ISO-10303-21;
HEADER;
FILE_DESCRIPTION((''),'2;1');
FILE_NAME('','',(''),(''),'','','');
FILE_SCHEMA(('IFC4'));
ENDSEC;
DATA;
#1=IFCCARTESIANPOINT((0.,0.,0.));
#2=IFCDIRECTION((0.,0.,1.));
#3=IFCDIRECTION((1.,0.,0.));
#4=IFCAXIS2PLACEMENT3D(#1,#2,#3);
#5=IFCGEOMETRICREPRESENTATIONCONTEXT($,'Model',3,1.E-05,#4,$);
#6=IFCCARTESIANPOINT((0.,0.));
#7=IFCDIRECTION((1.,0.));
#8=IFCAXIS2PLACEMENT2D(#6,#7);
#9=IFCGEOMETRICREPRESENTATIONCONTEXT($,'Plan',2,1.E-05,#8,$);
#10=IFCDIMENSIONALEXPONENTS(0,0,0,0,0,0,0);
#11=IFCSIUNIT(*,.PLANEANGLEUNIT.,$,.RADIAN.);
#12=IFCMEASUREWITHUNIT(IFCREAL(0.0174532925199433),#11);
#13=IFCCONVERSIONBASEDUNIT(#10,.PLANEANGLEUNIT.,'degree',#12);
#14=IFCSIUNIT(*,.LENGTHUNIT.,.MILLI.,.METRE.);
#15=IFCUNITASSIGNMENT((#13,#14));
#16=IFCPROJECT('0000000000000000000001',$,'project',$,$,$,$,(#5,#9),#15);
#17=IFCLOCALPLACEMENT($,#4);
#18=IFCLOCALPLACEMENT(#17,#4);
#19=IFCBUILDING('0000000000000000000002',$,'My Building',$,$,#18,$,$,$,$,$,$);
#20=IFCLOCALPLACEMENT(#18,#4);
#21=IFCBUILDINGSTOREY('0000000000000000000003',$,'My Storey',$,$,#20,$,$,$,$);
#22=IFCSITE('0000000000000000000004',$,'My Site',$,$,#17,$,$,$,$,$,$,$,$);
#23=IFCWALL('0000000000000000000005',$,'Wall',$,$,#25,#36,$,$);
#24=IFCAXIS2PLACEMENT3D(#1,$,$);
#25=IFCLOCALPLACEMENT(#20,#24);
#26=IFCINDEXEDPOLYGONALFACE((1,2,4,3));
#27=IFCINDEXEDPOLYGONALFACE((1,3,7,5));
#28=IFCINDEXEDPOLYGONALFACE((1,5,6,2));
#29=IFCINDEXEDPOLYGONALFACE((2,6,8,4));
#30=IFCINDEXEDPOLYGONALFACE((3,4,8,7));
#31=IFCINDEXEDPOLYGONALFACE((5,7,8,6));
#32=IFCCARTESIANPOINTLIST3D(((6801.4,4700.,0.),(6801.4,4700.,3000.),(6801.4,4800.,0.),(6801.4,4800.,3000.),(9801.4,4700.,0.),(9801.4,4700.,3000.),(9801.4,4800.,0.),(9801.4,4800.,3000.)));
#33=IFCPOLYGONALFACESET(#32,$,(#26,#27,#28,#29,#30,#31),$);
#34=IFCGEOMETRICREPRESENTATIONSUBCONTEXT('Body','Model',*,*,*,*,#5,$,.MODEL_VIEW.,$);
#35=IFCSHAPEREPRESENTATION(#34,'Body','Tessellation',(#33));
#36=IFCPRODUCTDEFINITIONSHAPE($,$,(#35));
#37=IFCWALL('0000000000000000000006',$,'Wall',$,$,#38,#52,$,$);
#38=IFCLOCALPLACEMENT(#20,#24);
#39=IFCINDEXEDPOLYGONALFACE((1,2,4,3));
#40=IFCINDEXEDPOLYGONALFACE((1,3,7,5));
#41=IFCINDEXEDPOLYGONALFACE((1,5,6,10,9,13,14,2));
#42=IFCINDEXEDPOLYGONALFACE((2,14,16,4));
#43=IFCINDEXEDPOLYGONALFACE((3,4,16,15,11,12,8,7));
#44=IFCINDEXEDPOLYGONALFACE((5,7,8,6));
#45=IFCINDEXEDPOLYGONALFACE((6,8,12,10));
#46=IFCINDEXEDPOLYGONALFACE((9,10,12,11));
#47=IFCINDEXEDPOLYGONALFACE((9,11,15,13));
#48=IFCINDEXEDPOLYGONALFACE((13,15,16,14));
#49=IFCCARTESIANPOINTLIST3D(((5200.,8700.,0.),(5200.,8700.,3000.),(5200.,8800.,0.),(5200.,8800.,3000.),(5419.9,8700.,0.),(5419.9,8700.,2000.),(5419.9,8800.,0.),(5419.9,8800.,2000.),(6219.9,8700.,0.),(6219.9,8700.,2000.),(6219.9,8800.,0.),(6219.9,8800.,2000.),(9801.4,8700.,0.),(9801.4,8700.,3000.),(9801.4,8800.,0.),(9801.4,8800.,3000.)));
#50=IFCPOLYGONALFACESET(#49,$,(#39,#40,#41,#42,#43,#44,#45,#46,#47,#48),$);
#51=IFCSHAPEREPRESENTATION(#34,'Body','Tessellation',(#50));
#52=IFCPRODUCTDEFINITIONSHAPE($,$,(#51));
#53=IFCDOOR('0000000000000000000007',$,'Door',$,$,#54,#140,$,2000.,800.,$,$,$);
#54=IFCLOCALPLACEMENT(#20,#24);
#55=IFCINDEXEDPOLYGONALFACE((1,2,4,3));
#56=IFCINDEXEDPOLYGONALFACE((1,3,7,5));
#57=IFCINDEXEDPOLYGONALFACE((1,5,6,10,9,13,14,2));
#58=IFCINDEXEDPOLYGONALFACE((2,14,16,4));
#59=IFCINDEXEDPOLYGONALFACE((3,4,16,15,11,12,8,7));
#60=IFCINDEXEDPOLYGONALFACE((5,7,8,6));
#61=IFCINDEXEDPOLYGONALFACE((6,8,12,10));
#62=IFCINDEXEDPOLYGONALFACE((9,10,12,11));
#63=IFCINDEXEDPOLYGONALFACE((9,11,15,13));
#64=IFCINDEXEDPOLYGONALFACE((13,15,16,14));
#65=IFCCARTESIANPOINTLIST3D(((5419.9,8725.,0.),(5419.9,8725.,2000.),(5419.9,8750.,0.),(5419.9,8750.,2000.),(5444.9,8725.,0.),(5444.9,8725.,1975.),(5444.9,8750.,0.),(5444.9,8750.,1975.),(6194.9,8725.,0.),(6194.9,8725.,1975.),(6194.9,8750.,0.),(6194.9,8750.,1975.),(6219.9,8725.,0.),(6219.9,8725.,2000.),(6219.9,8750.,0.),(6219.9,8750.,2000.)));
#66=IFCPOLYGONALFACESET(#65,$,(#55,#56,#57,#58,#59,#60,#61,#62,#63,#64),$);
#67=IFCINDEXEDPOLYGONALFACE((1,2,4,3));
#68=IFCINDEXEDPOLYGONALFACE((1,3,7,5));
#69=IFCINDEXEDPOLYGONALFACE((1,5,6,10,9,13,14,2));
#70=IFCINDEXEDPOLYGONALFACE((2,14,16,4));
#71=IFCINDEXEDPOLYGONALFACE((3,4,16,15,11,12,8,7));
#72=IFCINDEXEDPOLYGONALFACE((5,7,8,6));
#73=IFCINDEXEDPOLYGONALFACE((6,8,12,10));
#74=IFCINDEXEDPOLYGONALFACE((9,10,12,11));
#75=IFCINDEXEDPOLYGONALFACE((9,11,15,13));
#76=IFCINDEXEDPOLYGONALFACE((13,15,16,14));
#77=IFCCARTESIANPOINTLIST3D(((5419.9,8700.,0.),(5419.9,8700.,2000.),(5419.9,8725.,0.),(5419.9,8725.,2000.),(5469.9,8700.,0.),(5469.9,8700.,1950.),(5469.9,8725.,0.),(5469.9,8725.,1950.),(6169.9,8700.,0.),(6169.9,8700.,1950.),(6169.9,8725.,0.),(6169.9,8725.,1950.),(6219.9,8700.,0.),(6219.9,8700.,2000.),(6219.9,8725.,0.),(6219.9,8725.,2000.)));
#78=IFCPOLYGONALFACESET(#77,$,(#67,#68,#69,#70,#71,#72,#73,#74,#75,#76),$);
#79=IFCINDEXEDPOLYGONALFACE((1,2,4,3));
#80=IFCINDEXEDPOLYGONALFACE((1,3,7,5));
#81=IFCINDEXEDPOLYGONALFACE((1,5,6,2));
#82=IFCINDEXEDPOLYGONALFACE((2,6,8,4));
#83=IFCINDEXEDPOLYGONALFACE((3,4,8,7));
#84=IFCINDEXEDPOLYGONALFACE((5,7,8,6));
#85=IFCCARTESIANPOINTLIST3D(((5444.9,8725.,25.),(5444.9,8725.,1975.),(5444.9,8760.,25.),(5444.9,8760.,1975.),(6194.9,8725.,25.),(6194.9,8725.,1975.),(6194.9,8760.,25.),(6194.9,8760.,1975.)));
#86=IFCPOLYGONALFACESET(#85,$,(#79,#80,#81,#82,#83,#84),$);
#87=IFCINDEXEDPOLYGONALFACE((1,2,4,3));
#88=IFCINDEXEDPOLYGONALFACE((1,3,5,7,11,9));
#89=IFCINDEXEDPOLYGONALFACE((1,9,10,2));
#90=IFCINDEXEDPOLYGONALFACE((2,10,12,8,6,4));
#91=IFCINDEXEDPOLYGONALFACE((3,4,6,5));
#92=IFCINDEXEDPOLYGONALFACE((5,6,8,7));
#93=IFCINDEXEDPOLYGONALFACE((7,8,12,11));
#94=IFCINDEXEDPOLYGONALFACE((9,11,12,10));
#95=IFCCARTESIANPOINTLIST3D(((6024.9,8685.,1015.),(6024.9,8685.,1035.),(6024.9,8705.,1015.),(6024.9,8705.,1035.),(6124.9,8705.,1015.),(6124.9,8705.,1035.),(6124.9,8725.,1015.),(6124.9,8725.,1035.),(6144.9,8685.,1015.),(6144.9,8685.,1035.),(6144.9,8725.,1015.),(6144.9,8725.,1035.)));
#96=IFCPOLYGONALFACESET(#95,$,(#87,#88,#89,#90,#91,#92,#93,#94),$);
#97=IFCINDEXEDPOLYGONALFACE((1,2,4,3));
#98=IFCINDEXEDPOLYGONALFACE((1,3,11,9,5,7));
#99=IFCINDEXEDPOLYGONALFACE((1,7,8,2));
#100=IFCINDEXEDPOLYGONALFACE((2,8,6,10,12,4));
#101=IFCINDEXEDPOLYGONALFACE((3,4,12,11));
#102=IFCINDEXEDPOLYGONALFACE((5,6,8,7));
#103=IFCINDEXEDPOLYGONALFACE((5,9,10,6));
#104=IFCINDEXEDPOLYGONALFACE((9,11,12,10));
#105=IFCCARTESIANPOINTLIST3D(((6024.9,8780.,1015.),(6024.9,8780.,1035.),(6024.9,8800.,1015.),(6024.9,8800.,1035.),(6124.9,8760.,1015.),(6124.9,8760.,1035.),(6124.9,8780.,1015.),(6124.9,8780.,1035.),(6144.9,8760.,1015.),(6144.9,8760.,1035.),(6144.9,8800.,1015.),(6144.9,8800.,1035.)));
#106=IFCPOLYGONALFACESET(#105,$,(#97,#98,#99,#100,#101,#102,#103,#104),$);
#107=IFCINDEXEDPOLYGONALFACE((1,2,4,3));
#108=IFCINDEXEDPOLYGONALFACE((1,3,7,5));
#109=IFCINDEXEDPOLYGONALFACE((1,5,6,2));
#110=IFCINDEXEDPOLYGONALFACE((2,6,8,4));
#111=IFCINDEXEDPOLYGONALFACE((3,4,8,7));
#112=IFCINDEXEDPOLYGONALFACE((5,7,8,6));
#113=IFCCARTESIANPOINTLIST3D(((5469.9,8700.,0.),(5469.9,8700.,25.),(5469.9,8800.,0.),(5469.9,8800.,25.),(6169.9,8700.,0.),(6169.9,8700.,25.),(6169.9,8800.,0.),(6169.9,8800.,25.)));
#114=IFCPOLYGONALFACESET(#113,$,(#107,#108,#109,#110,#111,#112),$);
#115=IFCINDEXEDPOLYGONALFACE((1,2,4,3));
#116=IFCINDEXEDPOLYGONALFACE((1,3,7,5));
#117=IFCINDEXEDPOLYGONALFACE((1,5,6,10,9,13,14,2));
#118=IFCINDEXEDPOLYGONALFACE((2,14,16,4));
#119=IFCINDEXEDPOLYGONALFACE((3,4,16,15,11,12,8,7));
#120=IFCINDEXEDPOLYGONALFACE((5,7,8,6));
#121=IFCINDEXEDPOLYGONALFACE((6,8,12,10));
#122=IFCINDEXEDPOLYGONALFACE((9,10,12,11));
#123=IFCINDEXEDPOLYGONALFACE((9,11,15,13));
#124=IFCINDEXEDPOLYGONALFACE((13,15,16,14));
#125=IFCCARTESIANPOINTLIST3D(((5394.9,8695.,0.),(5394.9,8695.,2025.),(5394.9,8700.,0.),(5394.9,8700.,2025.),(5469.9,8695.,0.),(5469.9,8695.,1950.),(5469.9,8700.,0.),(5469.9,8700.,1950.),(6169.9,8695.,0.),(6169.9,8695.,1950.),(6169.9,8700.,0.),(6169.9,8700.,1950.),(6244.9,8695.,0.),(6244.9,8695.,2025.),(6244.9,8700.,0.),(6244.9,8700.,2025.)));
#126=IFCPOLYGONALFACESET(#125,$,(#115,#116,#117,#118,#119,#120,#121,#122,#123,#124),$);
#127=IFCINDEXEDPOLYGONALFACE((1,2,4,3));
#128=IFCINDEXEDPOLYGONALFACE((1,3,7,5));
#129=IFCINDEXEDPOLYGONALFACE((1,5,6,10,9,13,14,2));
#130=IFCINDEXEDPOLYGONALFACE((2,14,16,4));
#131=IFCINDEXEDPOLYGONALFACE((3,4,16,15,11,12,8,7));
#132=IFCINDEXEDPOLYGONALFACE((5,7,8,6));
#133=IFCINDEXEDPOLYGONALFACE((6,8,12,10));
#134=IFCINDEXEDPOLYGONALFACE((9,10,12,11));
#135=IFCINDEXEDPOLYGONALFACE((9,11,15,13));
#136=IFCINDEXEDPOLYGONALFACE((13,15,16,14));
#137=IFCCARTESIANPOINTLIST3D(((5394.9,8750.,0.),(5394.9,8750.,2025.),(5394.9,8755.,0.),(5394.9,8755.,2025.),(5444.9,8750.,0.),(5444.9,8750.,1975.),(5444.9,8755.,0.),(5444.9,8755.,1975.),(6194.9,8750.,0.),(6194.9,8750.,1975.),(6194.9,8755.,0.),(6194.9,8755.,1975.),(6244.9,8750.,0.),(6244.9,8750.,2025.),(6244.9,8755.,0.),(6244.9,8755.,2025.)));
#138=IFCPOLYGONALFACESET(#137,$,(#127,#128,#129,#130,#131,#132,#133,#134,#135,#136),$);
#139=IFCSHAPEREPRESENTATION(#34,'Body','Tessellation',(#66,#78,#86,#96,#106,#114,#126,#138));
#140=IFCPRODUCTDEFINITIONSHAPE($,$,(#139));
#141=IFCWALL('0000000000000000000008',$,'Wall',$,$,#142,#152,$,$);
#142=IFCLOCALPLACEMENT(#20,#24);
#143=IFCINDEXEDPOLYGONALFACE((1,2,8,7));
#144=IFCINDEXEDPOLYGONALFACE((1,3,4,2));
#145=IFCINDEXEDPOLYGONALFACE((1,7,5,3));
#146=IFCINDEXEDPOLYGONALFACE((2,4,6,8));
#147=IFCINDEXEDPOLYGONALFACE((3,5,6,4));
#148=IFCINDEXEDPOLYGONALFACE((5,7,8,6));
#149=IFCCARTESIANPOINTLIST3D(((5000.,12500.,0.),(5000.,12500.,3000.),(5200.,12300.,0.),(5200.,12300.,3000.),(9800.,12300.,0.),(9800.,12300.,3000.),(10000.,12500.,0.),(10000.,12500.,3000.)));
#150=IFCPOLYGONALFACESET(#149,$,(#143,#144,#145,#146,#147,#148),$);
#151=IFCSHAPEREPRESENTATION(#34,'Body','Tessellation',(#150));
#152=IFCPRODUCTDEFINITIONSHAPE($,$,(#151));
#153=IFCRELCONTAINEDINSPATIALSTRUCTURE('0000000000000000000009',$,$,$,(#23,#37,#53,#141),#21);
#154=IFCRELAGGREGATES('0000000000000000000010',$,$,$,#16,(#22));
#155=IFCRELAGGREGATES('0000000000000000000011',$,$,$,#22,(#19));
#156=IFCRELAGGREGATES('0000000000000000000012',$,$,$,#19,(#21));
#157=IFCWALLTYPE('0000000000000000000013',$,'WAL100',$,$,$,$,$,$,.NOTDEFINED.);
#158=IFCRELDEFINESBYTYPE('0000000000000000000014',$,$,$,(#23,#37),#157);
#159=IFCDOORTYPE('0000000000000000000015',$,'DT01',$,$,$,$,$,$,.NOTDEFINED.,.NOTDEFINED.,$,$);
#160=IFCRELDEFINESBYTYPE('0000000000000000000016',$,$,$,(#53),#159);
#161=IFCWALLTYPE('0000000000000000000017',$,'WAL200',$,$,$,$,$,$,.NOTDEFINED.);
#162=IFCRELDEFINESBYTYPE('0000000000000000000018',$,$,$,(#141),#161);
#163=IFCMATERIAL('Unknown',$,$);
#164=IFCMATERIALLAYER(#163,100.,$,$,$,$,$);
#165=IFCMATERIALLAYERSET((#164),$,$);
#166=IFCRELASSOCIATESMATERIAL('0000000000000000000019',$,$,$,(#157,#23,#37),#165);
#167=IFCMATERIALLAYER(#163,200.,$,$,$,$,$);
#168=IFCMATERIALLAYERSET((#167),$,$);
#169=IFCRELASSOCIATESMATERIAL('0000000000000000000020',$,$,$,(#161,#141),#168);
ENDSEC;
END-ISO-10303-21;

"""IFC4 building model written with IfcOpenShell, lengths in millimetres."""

from ifc_helpers import new_model, entity, si_unit, converted_unit, frame, origin_with_axes, origin_2d_with_axis, place, context, subcontext, project, spatial, line, indexed_curve, outline, extrude, clip, halfspace, shape, source, transform, mapped, material, layer, layer_set, layer_usage, type_object, type_shapes, element, fill, save


model = new_model("IFC4")

# Units and contexts
model_context = context("Model", 3, precision=1e-05, world=origin_with_axes())
plan_context = context("Plan", 2, precision=1e-05, world=origin_2d_with_axis())
body_context_1 = subcontext(model_context, "Body", "Model", "MODEL_VIEW")
body_context_2 = subcontext(plan_context, "Body", "Plan", "PLAN_VIEW")
ifc_project = project(units=[converted_unit("PLANEANGLEUNIT", "degree", entity("IfcReal", 0.0174532925199433), si_unit("PLANEANGLEUNIT", "RADIAN"), dimensions=[0, 0, 0, 0, 0, 0, 0]), si_unit("LENGTHUNIT", "METRE", prefix="MILLI")], contexts=[model_context, plan_context])

# Site, building, storey
site_placement = place(None, origin_with_axes())
site = spatial("IfcSite", under=ifc_project, at=site_placement, Name="My Site")
building_placement = place(site_placement, origin_with_axes())
building = spatial("IfcBuilding", under=site, at=building_placement, Name="My Building")
storey_placement = place(building_placement, origin_with_axes())
storey = spatial("IfcBuildingStorey", under=building, at=storey_placement, Name="My Storey")

# Wall
ifc_material = material(Name="Unknown")
ifc_layer_1 = layer(ifc_material, 100.0)
ifc_layer_set_1 = layer_set([ifc_layer_1])
ifc_layer_usage_1 = layer_usage(ifc_layer_set_1, "AXIS2", "POSITIVE", 0.0)
wall_type_1 = type_object("IfcWallType", Name="WAL100", PredefinedType="NOTDEFINED", material=ifc_layer_set_1)
wall_1_placement = place(storey_placement, frame((9801.4, 4800.0, 0.0), z_axis=(0.0, 0.0, 1.0), x_axis=(-1.0, 0.0, 0.0)))
element("IfcWall", 1, at=wall_1_placement, inside=storey, type_object=wall_type_1, material=ifc_layer_usage_1, Name="Wall", context=body_context_1, shape_type="SweptSolid", body=[
    extrude(outline(indexed_curve([(0.0, 0.0), (0.0, 100.0), (3000.0, 100.0), (3000.0, 0.0), (0.0, 0.0)], self_intersect=False)), origin_with_axes(), (0.0, 0.0, 1.0), 3000.0),
])

# Wall, opening, door
ifc_layer_usage_2 = layer_usage(ifc_layer_set_1, "AXIS2", "POSITIVE", 0.0)
wall_2_placement = place(storey_placement, frame((9801.4, 8800.0, 0.0), z_axis=(0.0, 0.0, 1.0), x_axis=(-1.0, 0.0, 0.0)))
wall_2 = element("IfcWall", 2, at=wall_2_placement, inside=storey, type_object=wall_type_1, material=ifc_layer_usage_2, Name="Wall", context=body_context_1, shape_type="SweptSolid", body=[
    extrude(outline(indexed_curve([(0.0, 0.0), (0.0, 100.0), (4601.4, 100.0), (4601.4, 0.0), (0.0, 0.0)], self_intersect=False)), origin_with_axes(), (0.0, 0.0, 1.0), 3000.0),
])
shared_shape_1 = source(origin_with_axes(), body_context_1, "Body", "SolidModel", [
    extrude(outline(indexed_curve([(0.0, 0.0), (800.0, 0.0), (800.0, 2000.0), (0.0, 2000.0)], segments=[line(1, 2, 3, 4, 1)])), frame((0.0, -600.0, 0.0), z_axis=(0.0, -1.0, 0.0), x_axis=(1.0, 0.0, 0.0)), (0.0, 0.0, -1.0), 1200.0),
])
opening_1_placement = place(wall_2_placement, frame((4381.5, 100.0, 0.0), z_axis=(0.0, 0.0, 1.0), x_axis=(-1.0, 0.0, 0.0)))
opening_1 = element("IfcOpeningElement", 3, at=opening_1_placement, cuts=wall_2, PredefinedType="OPENING", context=body_context_1, shape_type="MappedRepresentation", body=[
    mapped(shared_shape_1, transform((0.0, 0.0, 0.0), x_axis=(1.0, 0.0, 0.0), y_axis=(0.0, 1.0, 0.0), z_axis=(0.0, 0.0, 1.0), scale=1.0)),
])
door_type = type_object("IfcDoorType", Name="DT01", OperationType="NOTDEFINED", PredefinedType="NOTDEFINED")
shared_shape_2 = source(origin_with_axes(), body_context_1, "Body", "SolidModel", [
    extrude(outline(indexed_curve([(0.0, 0.0), (0.0, 2000.0), (800.0, 2000.0), (800.0, 0.0), (775.0, 0.0), (775.0, 1975.0), (25.0, 1975.0), (25.0, 0.0)], segments=[line(1, 2, 3, 4, 5, 6, 7, 8, 1)])), frame((0.0, 25.0, 0.0), z_axis=(0.0, -1.0, 0.0), x_axis=(1.0, 0.0, 0.0)), (0.0, 0.0, -1.0), 25.0),
    extrude(outline(indexed_curve([(0.0, 0.0), (0.0, 2000.0), (800.0, 2000.0), (800.0, 0.0), (750.0, 0.0), (750.0, 1950.0), (50.0, 1950.0), (50.0, 0.0)], segments=[line(1, 2, 3, 4, 5, 6, 7, 8, 1)])), frame((0.0, 0.0, 0.0), z_axis=(0.0, -1.0, 0.0), x_axis=(1.0, 0.0, 0.0)), (0.0, 0.0, -1.0), 25.0),
    extrude(outline(indexed_curve([(0.0, 0.0), (750.0, 0.0), (750.0, 35.0), (0.0, 35.0)], segments=[line(1, 2, 3, 4, 1)])), frame((25.0, 25.0, 25.0), z_axis=(0.0, 0.0, 1.0), x_axis=(1.0, 0.0, 0.0)), (0.0, 0.0, 1.0), 1950.0),
    extrude(outline(indexed_curve([(0.0, 0.0), (0.0, -40.0), (-120.0, -40.0), (-120.0, -20.0), (-20.0, -20.0), (-20.0, 0.0)], segments=[line(1, 2, 3, 4, 5, 6, 1)])), frame((725.0, 25.0, 1015.0), z_axis=(0.0, 0.0, 1.0), x_axis=(1.0, 0.0, 0.0)), (0.0, 0.0, 1.0), 20.0),
    extrude(outline(indexed_curve([(0.0, 0.0), (0.0, 40.0), (-120.0, 40.0), (-120.0, 20.0), (-20.0, 20.0), (-20.0, 0.0)], segments=[line(1, 2, 3, 4, 5, 6, 1)])), frame((725.0, 60.0, 1015.0), z_axis=(0.0, 0.0, 1.0), x_axis=(1.0, 0.0, 0.0)), (0.0, 0.0, 1.0), 20.0),
    extrude(outline(indexed_curve([(0.0, 0.0), (700.0, 0.0), (700.0, 100.0), (0.0, 100.0)], segments=[line(1, 2, 3, 4, 1)])), frame((50.0, 0.0, 0.0), z_axis=(0.0, 0.0, 1.0), x_axis=(1.0, 0.0, 0.0)), (0.0, 0.0, 1.0), 25.0),
    extrude(outline(indexed_curve([(0.0, 0.0), (0.0, 2025.0), (850.0, 2025.0), (850.0, 0.0), (775.0, 0.0), (775.0, 1950.0), (75.0, 1950.0), (75.0, 0.0)], segments=[line(1, 2, 3, 4, 5, 6, 7, 8, 1)])), frame((-25.0, -5.0, 0.0), z_axis=(0.0, -1.0, 0.0), x_axis=(1.0, 0.0, 0.0)), (0.0, 0.0, -1.0), 5.0),
    extrude(outline(indexed_curve([(0.0, 0.0), (0.0, 2025.0), (850.0, 2025.0), (850.0, 0.0), (800.0, 0.0), (800.0, 1975.0), (50.0, 1975.0), (50.0, 0.0)], segments=[line(1, 2, 3, 4, 5, 6, 7, 8, 1)])), frame((-25.0, 50.0, 0.0), z_axis=(0.0, -1.0, 0.0), x_axis=(1.0, 0.0, 0.0)), (0.0, 0.0, -1.0), 5.0),
])
shared_shape_3 = source(origin_with_axes(), body_context_2, "Body", "Curve2D", [
    entity("IfcIndexedPolyCurve", entity("IfcCartesianPointList2D", [[0.0, 0.0], [0.0, 50.0], [25.0, 50.0], [25.0, 25.0], [50.0, 25.0], [50.0, 0.0]]), [entity("IfcLineIndex", [1, 2, 3, 4, 5, 6, 1])]),
    entity("IfcIndexedPolyCurve", entity("IfcCartesianPointList2D", [[800.0, 0.0], [800.0, 50.0], [775.0, 50.0], [775.0, 25.0], [750.0, 25.0], [750.0, 0.0]]), [entity("IfcLineIndex", [1, 2, 3, 4, 5, 6, 1])]),
    entity("IfcTrimmedCurve", entity("IfcEllipse", entity("IfcAxis2Placement2D", entity("IfcCartesianPoint", [60.0, 50.0]), entity("IfcDirection", [1.0, 0.0])), 715.0, 750.0), [entity("IfcCartesianPoint", [775.0, 50.0])], [entity("IfcCartesianPoint", [60.0, 800.0])], True, "CARTESIAN"),
    entity("IfcIndexedPolyCurve", entity("IfcCartesianPointList2D", [[25.0, 50.0], [60.0, 50.0], [60.0, 800.0], [25.0, 800.0]]), [entity("IfcLineIndex", [1, 2, 3, 4, 1])]),
])
type_shapes(door_type, [shared_shape_2, shared_shape_3])
door_1_placement = place(opening_1_placement, frame((0.0, 0.0, 0.0), z_axis=(0.0, 0.0, 1.0), x_axis=(1.0, 0.0, 0.0)))
door_1 = element("IfcDoor", 4, at=door_1_placement, inside=storey, type_object=door_type, Name="Door", OverallHeight=2000.0, OverallWidth=800.0, shapes=[
    shape(body_context_1, "Body", "MappedRepresentation", [mapped(shared_shape_2, transform((0.0, 0.0, 0.0), x_axis=(1.0, 0.0, 0.0), y_axis=(0.0, 1.0, 0.0), z_axis=(0.0, 0.0, 1.0), scale=1.0))]),
    shape(body_context_2, "Body", "MappedRepresentation", [mapped(shared_shape_3, transform((0.0, 0.0, 0.0), x_axis=(1.0, 0.0, 0.0), y_axis=(0.0, 1.0, 0.0), z_axis=(0.0, 0.0, 1.0), scale=1.0))]),
])
fill(opening_1, door_1)

# Wall
ifc_layer_2 = layer(ifc_material, 200.0)
ifc_layer_set_2 = layer_set([ifc_layer_2])
ifc_layer_usage_3 = layer_usage(ifc_layer_set_2, "AXIS2", "POSITIVE", 0.0)
wall_type_2 = type_object("IfcWallType", Name="WAL200", PredefinedType="NOTDEFINED", material=ifc_layer_set_2)
wall_3_placement = place(storey_placement, frame((10000.0, 12500.0, 0.0), z_axis=(0.0, 0.0, 1.0), x_axis=(-1.0, 0.0, 0.0)))
element("IfcWall", 5, at=wall_3_placement, inside=storey, type_object=wall_type_2, material=ifc_layer_usage_3, Name="Wall", context=body_context_1, shape_type="Clipping", body=[
    clip(clip(extrude(outline(indexed_curve([(0.0, 0.0), (0.0, 200.0), (5000.0, 200.0), (5000.0, 0.0), (0.0, 0.0)], self_intersect=False)), origin_with_axes(), (0.0, 0.0, 1.0), 3000.0), halfspace(frame((5000.0, 0.0, 0.0), z_axis=(0.707106, 0.707107, 0.0), x_axis=(0.707107, -0.707106, 0.0)), False)), halfspace(frame((0.0, 0.0, 0.0), z_axis=(-0.707107, 0.707106, 0.0), x_axis=(0.707106, 0.707107, 0.0)), False)),
])

save(model, "model.ifc")
